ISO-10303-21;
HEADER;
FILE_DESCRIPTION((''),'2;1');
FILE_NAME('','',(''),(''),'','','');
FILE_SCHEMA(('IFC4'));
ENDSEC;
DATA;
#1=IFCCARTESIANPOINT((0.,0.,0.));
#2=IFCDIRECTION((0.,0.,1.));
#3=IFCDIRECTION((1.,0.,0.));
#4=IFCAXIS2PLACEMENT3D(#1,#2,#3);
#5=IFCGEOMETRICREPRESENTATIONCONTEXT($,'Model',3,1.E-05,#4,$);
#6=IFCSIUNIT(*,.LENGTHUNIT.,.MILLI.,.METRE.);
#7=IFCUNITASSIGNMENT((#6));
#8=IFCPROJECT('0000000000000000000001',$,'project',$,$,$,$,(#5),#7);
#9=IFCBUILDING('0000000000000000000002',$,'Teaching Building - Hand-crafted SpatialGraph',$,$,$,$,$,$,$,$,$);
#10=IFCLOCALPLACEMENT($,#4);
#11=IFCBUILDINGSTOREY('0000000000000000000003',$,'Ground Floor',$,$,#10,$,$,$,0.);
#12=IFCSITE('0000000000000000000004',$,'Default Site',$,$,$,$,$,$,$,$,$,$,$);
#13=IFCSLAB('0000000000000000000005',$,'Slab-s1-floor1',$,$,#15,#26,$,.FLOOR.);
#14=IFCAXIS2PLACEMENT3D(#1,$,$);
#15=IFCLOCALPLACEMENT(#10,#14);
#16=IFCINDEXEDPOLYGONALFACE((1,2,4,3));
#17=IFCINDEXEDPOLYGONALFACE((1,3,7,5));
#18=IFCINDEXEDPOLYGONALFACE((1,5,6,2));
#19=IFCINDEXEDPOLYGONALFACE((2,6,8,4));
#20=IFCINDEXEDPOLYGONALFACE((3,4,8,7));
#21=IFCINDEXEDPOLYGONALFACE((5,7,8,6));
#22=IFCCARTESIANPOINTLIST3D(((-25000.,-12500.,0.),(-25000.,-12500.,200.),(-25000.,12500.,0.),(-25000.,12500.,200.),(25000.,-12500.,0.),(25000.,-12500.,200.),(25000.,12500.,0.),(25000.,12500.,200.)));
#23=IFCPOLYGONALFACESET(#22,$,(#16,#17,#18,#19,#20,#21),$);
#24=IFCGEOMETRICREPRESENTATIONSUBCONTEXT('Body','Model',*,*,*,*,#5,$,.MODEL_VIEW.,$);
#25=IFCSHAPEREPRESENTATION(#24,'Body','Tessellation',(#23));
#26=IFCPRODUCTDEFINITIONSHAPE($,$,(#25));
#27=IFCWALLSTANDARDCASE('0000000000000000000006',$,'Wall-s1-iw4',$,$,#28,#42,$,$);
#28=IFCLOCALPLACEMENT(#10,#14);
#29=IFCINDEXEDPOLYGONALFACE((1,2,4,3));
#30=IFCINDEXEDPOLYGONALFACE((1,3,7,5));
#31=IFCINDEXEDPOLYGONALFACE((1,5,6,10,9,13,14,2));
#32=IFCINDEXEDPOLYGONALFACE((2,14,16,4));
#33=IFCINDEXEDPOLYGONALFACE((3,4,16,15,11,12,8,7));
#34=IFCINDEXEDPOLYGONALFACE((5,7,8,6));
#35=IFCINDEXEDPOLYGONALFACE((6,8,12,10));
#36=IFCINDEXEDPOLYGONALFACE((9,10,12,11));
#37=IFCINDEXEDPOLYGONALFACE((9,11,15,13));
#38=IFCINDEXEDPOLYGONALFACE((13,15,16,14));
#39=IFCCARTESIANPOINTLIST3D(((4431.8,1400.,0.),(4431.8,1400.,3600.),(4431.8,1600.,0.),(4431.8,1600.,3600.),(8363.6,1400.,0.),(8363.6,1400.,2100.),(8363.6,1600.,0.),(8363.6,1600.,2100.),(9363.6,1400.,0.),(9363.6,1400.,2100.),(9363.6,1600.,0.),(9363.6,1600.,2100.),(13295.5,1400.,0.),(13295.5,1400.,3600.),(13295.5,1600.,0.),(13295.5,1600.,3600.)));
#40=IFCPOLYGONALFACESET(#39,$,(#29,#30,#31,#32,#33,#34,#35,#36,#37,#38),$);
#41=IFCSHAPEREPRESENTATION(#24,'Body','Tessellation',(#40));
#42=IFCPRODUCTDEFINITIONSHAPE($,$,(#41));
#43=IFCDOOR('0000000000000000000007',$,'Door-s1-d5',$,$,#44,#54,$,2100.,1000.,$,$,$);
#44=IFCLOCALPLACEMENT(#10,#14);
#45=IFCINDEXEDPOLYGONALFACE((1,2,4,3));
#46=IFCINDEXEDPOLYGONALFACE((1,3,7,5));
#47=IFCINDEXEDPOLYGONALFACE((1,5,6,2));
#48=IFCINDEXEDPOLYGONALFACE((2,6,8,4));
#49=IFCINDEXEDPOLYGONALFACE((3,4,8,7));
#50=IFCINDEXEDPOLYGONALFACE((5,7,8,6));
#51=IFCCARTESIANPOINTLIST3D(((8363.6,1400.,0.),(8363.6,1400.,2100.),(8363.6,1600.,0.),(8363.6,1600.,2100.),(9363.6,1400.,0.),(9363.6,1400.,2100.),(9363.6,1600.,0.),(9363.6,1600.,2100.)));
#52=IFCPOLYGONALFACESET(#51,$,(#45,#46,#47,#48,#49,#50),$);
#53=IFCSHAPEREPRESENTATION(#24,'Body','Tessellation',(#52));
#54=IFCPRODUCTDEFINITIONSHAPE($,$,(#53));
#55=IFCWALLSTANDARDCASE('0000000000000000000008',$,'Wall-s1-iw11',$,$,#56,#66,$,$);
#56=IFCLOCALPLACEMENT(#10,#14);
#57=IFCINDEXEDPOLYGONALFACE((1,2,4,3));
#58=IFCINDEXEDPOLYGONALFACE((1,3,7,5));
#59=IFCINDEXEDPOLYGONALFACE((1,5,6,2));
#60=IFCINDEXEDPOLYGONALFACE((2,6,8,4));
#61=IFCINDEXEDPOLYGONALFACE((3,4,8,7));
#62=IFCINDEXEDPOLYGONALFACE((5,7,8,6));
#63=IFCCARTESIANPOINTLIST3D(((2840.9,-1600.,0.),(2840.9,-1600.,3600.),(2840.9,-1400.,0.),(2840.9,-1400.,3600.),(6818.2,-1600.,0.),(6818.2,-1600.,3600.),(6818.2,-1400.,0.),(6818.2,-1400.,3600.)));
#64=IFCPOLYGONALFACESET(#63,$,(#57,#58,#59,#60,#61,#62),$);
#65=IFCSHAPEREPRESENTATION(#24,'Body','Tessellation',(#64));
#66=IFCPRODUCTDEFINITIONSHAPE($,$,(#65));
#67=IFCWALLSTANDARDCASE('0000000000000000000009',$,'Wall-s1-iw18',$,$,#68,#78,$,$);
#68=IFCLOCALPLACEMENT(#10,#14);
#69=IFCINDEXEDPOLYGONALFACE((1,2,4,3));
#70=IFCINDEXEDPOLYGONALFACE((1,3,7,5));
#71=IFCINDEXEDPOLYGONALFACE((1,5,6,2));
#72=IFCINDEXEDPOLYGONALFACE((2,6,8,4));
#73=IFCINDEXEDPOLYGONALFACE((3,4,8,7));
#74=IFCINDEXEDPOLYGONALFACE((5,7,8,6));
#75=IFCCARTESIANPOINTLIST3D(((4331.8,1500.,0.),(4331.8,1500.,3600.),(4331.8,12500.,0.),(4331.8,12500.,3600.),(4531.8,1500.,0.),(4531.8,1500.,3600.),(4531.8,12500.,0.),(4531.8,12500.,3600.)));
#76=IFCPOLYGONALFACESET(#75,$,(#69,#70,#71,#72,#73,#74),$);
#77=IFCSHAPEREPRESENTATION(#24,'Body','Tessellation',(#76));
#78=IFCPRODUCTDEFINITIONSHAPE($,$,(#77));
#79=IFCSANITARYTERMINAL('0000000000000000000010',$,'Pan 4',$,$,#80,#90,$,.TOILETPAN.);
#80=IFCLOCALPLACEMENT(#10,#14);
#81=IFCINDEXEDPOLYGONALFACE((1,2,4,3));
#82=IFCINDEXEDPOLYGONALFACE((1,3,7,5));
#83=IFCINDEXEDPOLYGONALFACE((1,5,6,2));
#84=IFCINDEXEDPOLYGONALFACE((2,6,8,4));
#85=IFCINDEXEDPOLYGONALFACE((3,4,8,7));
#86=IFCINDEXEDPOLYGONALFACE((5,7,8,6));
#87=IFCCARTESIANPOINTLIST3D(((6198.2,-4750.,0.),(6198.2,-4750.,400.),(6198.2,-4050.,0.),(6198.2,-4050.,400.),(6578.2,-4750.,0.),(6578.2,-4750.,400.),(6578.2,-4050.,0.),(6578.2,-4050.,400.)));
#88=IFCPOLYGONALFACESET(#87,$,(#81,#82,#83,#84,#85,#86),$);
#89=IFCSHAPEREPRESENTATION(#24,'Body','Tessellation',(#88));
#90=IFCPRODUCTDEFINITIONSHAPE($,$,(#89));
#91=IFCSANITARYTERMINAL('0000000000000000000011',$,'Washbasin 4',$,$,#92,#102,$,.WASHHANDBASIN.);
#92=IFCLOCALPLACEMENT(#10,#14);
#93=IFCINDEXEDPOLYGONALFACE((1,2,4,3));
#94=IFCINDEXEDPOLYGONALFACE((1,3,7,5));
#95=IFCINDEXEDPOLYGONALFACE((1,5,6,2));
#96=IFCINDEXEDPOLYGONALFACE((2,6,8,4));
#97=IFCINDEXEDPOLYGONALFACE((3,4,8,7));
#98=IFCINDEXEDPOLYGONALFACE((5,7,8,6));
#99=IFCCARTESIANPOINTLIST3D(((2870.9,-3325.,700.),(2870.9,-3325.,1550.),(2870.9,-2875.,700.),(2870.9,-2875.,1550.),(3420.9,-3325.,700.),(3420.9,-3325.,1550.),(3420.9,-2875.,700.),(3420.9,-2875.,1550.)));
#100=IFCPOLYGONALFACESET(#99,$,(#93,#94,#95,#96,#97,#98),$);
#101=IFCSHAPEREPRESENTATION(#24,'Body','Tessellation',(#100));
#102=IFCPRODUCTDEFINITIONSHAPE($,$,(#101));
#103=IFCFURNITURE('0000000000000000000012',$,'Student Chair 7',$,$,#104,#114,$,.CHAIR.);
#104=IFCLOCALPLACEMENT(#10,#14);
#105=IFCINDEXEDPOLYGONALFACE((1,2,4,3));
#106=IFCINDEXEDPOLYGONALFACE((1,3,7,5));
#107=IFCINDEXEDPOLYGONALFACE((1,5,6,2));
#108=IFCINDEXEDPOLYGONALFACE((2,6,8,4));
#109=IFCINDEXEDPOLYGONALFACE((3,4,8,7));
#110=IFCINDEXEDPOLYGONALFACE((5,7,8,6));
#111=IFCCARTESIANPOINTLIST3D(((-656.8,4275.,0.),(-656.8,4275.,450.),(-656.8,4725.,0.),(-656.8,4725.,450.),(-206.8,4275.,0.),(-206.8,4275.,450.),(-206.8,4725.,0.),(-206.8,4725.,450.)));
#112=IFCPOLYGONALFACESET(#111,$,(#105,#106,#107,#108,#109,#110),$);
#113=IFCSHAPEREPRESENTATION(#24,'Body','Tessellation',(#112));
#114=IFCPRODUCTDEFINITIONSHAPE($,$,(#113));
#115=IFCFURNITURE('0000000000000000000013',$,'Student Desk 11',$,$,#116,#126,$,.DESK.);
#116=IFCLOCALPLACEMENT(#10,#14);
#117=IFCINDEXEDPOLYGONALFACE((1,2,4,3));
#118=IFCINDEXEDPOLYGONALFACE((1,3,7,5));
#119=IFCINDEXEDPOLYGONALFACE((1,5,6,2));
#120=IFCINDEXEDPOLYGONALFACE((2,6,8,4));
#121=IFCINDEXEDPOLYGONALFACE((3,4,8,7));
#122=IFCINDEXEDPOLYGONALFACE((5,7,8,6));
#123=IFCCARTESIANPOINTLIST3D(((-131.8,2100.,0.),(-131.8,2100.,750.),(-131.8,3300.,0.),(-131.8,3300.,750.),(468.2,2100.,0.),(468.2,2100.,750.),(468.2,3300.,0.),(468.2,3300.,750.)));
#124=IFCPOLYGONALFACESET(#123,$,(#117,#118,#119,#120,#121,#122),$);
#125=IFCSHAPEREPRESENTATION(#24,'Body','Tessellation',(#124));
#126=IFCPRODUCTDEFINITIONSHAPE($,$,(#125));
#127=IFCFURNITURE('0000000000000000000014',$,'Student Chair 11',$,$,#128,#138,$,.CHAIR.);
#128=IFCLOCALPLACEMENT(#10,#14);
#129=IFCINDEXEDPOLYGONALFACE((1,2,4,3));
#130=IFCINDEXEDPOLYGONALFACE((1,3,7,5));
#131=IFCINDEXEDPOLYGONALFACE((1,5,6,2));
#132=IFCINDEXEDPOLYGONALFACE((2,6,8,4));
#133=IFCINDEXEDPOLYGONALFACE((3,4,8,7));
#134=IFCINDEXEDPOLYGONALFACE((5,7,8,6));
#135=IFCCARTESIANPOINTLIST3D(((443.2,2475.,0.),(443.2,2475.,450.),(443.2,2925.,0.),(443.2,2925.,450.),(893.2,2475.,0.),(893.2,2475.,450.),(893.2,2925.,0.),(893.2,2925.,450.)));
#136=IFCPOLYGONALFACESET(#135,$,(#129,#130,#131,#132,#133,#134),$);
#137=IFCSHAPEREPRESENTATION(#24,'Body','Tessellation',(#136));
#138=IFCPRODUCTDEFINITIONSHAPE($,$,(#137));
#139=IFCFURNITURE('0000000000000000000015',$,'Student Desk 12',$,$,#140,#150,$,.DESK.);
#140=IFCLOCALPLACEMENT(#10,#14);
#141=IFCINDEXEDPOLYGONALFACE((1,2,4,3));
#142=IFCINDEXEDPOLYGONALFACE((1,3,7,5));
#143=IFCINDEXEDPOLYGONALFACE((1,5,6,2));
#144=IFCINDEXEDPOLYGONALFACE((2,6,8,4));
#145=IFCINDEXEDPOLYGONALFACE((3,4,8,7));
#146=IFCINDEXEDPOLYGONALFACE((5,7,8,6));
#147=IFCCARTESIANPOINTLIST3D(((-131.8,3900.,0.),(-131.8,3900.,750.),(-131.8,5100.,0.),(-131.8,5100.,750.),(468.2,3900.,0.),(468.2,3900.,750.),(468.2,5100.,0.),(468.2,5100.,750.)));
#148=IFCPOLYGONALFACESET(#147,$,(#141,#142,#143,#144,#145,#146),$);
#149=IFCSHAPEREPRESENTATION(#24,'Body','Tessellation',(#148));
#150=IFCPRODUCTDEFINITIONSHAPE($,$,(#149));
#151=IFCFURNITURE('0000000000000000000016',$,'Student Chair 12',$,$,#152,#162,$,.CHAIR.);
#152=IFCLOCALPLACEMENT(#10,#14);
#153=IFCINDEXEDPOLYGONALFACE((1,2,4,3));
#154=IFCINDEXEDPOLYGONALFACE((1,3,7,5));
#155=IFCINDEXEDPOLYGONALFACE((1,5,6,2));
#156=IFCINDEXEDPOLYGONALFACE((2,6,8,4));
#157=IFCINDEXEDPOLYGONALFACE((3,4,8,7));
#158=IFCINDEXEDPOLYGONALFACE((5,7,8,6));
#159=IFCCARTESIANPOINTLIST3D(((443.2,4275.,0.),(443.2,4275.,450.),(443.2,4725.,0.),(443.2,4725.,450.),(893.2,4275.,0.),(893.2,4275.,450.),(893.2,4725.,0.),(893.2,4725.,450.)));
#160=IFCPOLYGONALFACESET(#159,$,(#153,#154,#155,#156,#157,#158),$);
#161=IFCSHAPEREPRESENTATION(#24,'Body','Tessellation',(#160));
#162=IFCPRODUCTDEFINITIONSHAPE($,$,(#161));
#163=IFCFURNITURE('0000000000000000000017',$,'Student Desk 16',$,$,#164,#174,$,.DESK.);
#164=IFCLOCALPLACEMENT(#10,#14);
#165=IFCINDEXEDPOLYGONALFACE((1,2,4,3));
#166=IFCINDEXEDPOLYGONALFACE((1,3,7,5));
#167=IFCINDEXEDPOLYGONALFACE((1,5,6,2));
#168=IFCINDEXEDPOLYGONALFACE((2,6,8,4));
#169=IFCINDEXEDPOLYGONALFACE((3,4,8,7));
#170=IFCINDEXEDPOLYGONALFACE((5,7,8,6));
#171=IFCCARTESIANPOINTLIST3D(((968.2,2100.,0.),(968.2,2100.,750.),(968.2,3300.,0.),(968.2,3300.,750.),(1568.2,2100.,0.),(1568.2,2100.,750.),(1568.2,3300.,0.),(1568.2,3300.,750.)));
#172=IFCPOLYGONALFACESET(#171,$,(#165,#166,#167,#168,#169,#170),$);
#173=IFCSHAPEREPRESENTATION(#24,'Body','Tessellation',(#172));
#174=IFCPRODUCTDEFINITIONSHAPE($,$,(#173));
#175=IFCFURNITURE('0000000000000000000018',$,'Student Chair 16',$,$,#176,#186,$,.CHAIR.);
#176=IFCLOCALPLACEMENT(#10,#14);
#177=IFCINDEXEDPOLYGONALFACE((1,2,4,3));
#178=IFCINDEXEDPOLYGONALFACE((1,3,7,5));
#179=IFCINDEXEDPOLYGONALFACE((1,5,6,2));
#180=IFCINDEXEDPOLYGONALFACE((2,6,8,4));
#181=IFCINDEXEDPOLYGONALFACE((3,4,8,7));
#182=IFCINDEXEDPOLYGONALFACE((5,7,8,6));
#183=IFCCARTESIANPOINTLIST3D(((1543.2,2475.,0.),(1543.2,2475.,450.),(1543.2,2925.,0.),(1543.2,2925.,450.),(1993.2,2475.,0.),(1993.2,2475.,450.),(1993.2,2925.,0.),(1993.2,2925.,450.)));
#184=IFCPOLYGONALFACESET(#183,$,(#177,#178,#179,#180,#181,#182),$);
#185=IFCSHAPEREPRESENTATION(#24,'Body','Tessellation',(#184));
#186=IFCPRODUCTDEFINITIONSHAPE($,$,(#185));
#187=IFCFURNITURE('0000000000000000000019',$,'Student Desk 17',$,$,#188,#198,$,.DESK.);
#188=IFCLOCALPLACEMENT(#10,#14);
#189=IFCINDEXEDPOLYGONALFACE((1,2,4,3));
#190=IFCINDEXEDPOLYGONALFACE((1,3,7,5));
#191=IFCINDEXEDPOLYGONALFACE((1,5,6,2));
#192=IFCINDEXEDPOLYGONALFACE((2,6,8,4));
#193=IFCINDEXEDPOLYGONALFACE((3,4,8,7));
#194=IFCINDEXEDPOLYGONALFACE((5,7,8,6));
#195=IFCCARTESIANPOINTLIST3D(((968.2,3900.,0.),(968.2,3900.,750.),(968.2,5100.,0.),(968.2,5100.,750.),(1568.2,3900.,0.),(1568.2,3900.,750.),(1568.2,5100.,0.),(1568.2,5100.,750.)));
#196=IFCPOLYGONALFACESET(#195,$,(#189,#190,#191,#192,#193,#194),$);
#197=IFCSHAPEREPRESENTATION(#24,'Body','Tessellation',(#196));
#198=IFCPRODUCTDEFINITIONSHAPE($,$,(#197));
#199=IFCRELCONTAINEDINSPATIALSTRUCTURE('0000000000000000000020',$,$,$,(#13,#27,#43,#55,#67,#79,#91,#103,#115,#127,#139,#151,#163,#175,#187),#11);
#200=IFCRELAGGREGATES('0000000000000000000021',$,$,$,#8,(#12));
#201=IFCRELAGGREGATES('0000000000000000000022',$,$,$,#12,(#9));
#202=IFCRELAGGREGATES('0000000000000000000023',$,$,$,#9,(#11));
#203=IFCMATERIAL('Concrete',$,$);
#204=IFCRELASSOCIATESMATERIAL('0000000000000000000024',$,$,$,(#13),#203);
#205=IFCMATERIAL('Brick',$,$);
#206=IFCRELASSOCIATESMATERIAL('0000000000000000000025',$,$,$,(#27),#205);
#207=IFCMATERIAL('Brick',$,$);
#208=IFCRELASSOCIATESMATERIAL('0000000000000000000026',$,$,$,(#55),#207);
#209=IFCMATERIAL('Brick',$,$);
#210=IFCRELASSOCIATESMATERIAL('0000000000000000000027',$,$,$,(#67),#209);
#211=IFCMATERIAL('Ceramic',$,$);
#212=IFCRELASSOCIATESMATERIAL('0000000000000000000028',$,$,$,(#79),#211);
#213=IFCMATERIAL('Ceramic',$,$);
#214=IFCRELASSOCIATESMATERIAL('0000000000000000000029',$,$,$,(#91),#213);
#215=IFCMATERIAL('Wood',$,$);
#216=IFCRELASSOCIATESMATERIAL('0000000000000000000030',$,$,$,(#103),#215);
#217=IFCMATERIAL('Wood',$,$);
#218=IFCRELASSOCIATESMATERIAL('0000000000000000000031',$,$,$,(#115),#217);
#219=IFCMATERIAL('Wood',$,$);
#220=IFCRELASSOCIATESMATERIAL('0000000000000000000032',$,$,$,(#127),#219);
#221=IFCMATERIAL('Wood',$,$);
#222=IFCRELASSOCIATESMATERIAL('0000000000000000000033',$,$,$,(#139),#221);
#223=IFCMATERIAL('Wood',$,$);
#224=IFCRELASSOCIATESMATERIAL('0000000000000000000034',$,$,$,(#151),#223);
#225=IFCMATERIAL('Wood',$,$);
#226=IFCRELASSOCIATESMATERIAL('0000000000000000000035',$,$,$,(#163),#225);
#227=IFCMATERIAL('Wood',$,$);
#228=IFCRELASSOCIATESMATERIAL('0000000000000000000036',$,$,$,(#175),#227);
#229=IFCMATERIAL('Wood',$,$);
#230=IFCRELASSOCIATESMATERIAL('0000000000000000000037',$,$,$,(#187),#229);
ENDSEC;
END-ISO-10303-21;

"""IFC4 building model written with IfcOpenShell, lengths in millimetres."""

from ifc_helpers import new_model, si_unit, frame, frame_2d, origin_with_axes, origin_2d, place, context, subcontext, project, spatial, polyline, rectangle, outline, extrude, material, element, fill, save


model = new_model("IFC4")

# Units and contexts
model_context = context("Model", 3, precision=1e-05, world=origin_with_axes())
body_context = subcontext(model_context, "Body", "Model", "MODEL_VIEW")
ifc_project = project(units=[si_unit("LENGTHUNIT", "METRE", prefix="MILLI")], contexts=[model_context])

# Site, building, storey
site = spatial("IfcSite", under=ifc_project, Name="Default Site")
building = spatial("IfcBuilding", under=site, Name="Teaching Building - Hand-crafted SpatialGraph")
storey_placement = place(None, origin_with_axes())
storey = spatial("IfcBuildingStorey", under=building, at=storey_placement, Name="Ground Floor", Elevation=0.0)

# Slab
ifc_material_1 = material(Name="Concrete")
slab_placement = place(storey_placement, origin_with_axes())
element("IfcSlab", 1, at=slab_placement, inside=storey, material=ifc_material_1, Name="Slab-s1-floor1", PredefinedType="FLOOR", context=body_context, shape_type="SweptSolid", body=[
    extrude(outline(polyline([(-25000.0, -12500.0), (25000.0, -12500.0), (25000.0, 12500.0), (-25000.0, 12500.0), (-25000.0, -12500.0)])), origin_with_axes(), (0.0, 0.0, 1.0), 200.0),
])

# Wall, opening, door
ifc_material_2 = material(Name="Brick")
wall_1_placement = place(storey_placement, frame((4431.8, 1500.0, 0.0), z_axis=(0.0, 0.0, 1.0), x_axis=(1.0, 0.0, 0.0)))
wall_1 = element("IfcWallStandardCase", 2, at=wall_1_placement, inside=storey, material=ifc_material_2, Name="Wall-s1-iw4", context=body_context, shape_type="SweptSolid", body=[
    extrude(rectangle(XDim=8863.6, YDim=200.0, at=frame_2d((4431.8, 0.0))), origin_with_axes(), (0.0, 0.0, 1.0), 3600.0),
])
opening_placement = place(wall_1_placement, frame((3931.8, 0.0, 0.0), z_axis=(0.0, 0.0, 1.0), x_axis=(1.0, 0.0, 0.0)))
opening = element("IfcOpeningElement", 3, at=opening_placement, cuts=wall_1, context=body_context, shape_type="SweptSolid", body=[
    extrude(rectangle(XDim=1000.0, YDim=400.0, at=frame_2d((500.0, 0.0))), origin_with_axes(), (0.0, 0.0, 1.0), 2100.0),
])
door_placement = place(storey_placement, frame((8363.6, 1500.0, 0.0), z_axis=(0.0, 0.0, 1.0), x_axis=(1.0, 0.0, 0.0)))
door = element("IfcDoor", 4, at=door_placement, inside=storey, Name="Door-s1-d5", OverallHeight=2100.0, OverallWidth=1000.0, context=body_context, shape_type="SweptSolid", body=[
    extrude(rectangle(XDim=1000.0, YDim=200.0, at=frame_2d((500.0, 0.0))), origin_with_axes(), (0.0, 0.0, 1.0), 2100.0),
])
fill(opening, door)

# Walls
ifc_material_3 = material(Name="Brick")
wall_2_placement = place(storey_placement, frame((2840.9, -1500.0, 0.0), z_axis=(0.0, 0.0, 1.0), x_axis=(1.0, 0.0, 0.0)))
element("IfcWallStandardCase", 5, at=wall_2_placement, inside=storey, material=ifc_material_3, Name="Wall-s1-iw11", context=body_context, shape_type="SweptSolid", body=[
    extrude(rectangle(XDim=3977.3, YDim=200.0, at=frame_2d((1988.6, 0.0))), origin_with_axes(), (0.0, 0.0, 1.0), 3600.0),
])
ifc_material_4 = material(Name="Brick")
wall_3_placement = place(storey_placement, frame((4431.8, 1500.0, 0.0), z_axis=(0.0, 0.0, 1.0), x_axis=(0.0, 1.0, 0.0)))
element("IfcWallStandardCase", 6, at=wall_3_placement, inside=storey, material=ifc_material_4, Name="Wall-s1-iw18", context=body_context, shape_type="SweptSolid", body=[
    extrude(rectangle(XDim=11000.0, YDim=200.0, at=frame_2d((5500.0, 0.0))), origin_with_axes(), (0.0, 0.0, 1.0), 3600.0),
])

# Sanitary terminals
ifc_material_5 = material(Name="Ceramic")
sanitary_terminal_1_placement = place(storey_placement, frame((6388.2, -4400.0, 0.0), z_axis=(0.0, 0.0, 1.0), x_axis=(0.0, 1.0, 0.0)))
element("IfcSanitaryTerminal", 7, at=sanitary_terminal_1_placement, inside=storey, material=ifc_material_5, Name="Pan 4", PredefinedType="TOILETPAN", context=body_context, shape_type="SweptSolid", body=[
    extrude(rectangle(XDim=700.0, YDim=380.0, at=origin_2d()), origin_with_axes(), (0.0, 0.0, 1.0), 400.0),
])
ifc_material_6 = material(Name="Ceramic")
sanitary_terminal_2_placement = place(storey_placement, frame((3145.9, -3100.0, 700.0), z_axis=(0.0, 0.0, 1.0), x_axis=(0.0, 1.0, 0.0)))
element("IfcSanitaryTerminal", 8, at=sanitary_terminal_2_placement, inside=storey, material=ifc_material_6, Name="Washbasin 4", PredefinedType="WASHHANDBASIN", context=body_context, shape_type="SweptSolid", body=[
    extrude(rectangle(XDim=450.0, YDim=550.0, at=origin_2d()), origin_with_axes(), (0.0, 0.0, 1.0), 850.0),
])

# Furniture
ifc_material_7 = material(Name="Wood")
furniture_1_placement = place(storey_placement, frame((-431.8, 4500.0, 0.0), z_axis=(0.0, 0.0, 1.0), x_axis=(1.0, 0.0, 0.0)))
element("IfcFurniture", 9, at=furniture_1_placement, inside=storey, material=ifc_material_7, Name="Student Chair 7", PredefinedType="CHAIR", context=body_context, shape_type="SweptSolid", body=[
    extrude(rectangle(XDim=450.0, YDim=450.0, at=origin_2d()), origin_with_axes(), (0.0, 0.0, 1.0), 450.0),
])
ifc_material_8 = material(Name="Wood")
furniture_2_placement = place(storey_placement, frame((168.2, 2700.0, 0.0), z_axis=(0.0, 0.0, 1.0), x_axis=(0.0, 1.0, 0.0)))
element("IfcFurniture", 10, at=furniture_2_placement, inside=storey, material=ifc_material_8, Name="Student Desk 11", PredefinedType="DESK", context=body_context, shape_type="SweptSolid", body=[
    extrude(rectangle(XDim=1200.0, YDim=600.0, at=origin_2d()), origin_with_axes(), (0.0, 0.0, 1.0), 750.0),
])
ifc_material_9 = material(Name="Wood")
furniture_3_placement = place(storey_placement, frame((668.2, 2700.0, 0.0), z_axis=(0.0, 0.0, 1.0), x_axis=(1.0, 0.0, 0.0)))
element("IfcFurniture", 11, at=furniture_3_placement, inside=storey, material=ifc_material_9, Name="Student Chair 11", PredefinedType="CHAIR", context=body_context, shape_type="SweptSolid", body=[
    extrude(rectangle(XDim=450.0, YDim=450.0, at=origin_2d()), origin_with_axes(), (0.0, 0.0, 1.0), 450.0),
])
ifc_material_10 = material(Name="Wood")
furniture_4_placement = place(storey_placement, frame((168.2, 4500.0, 0.0), z_axis=(0.0, 0.0, 1.0), x_axis=(0.0, 1.0, 0.0)))
element("IfcFurniture", 12, at=furniture_4_placement, inside=storey, material=ifc_material_10, Name="Student Desk 12", PredefinedType="DESK", context=body_context, shape_type="SweptSolid", body=[
    extrude(rectangle(XDim=1200.0, YDim=600.0, at=origin_2d()), origin_with_axes(), (0.0, 0.0, 1.0), 750.0),
])
ifc_material_11 = material(Name="Wood")
furniture_5_placement = place(storey_placement, frame((668.2, 4500.0, 0.0), z_axis=(0.0, 0.0, 1.0), x_axis=(1.0, 0.0, 0.0)))
element("IfcFurniture", 13, at=furniture_5_placement, inside=storey, material=ifc_material_11, Name="Student Chair 12", PredefinedType="CHAIR", context=body_context, shape_type="SweptSolid", body=[
    extrude(rectangle(XDim=450.0, YDim=450.0, at=origin_2d()), origin_with_axes(), (0.0, 0.0, 1.0), 450.0),
])
ifc_material_12 = material(Name="Wood")
furniture_6_placement = place(storey_placement, frame((1268.2, 2700.0, 0.0), z_axis=(0.0, 0.0, 1.0), x_axis=(0.0, 1.0, 0.0)))
element("IfcFurniture", 14, at=furniture_6_placement, inside=storey, material=ifc_material_12, Name="Student Desk 16", PredefinedType="DESK", context=body_context, shape_type="SweptSolid", body=[
    extrude(rectangle(XDim=1200.0, YDim=600.0, at=origin_2d()), origin_with_axes(), (0.0, 0.0, 1.0), 750.0),
])
ifc_material_13 = material(Name="Wood")
furniture_7_placement = place(storey_placement, frame((1768.2, 2700.0, 0.0), z_axis=(0.0, 0.0, 1.0), x_axis=(1.0, 0.0, 0.0)))
element("IfcFurniture", 15, at=furniture_7_placement, inside=storey, material=ifc_material_13, Name="Student Chair 16", PredefinedType="CHAIR", context=body_context, shape_type="SweptSolid", body=[
    extrude(rectangle(XDim=450.0, YDim=450.0, at=origin_2d()), origin_with_axes(), (0.0, 0.0, 1.0), 450.0),
])
ifc_material_14 = material(Name="Wood")
furniture_8_placement = place(storey_placement, frame((1268.2, 4500.0, 0.0), z_axis=(0.0, 0.0, 1.0), x_axis=(0.0, 1.0, 0.0)))
element("IfcFurniture", 16, at=furniture_8_placement, inside=storey, material=ifc_material_14, Name="Student Desk 17", PredefinedType="DESK", context=body_context, shape_type="SweptSolid", body=[
    extrude(rectangle(XDim=1200.0, YDim=600.0, at=origin_2d()), origin_with_axes(), (0.0, 0.0, 1.0), 750.0),
])

save(model, "model.ifc")
